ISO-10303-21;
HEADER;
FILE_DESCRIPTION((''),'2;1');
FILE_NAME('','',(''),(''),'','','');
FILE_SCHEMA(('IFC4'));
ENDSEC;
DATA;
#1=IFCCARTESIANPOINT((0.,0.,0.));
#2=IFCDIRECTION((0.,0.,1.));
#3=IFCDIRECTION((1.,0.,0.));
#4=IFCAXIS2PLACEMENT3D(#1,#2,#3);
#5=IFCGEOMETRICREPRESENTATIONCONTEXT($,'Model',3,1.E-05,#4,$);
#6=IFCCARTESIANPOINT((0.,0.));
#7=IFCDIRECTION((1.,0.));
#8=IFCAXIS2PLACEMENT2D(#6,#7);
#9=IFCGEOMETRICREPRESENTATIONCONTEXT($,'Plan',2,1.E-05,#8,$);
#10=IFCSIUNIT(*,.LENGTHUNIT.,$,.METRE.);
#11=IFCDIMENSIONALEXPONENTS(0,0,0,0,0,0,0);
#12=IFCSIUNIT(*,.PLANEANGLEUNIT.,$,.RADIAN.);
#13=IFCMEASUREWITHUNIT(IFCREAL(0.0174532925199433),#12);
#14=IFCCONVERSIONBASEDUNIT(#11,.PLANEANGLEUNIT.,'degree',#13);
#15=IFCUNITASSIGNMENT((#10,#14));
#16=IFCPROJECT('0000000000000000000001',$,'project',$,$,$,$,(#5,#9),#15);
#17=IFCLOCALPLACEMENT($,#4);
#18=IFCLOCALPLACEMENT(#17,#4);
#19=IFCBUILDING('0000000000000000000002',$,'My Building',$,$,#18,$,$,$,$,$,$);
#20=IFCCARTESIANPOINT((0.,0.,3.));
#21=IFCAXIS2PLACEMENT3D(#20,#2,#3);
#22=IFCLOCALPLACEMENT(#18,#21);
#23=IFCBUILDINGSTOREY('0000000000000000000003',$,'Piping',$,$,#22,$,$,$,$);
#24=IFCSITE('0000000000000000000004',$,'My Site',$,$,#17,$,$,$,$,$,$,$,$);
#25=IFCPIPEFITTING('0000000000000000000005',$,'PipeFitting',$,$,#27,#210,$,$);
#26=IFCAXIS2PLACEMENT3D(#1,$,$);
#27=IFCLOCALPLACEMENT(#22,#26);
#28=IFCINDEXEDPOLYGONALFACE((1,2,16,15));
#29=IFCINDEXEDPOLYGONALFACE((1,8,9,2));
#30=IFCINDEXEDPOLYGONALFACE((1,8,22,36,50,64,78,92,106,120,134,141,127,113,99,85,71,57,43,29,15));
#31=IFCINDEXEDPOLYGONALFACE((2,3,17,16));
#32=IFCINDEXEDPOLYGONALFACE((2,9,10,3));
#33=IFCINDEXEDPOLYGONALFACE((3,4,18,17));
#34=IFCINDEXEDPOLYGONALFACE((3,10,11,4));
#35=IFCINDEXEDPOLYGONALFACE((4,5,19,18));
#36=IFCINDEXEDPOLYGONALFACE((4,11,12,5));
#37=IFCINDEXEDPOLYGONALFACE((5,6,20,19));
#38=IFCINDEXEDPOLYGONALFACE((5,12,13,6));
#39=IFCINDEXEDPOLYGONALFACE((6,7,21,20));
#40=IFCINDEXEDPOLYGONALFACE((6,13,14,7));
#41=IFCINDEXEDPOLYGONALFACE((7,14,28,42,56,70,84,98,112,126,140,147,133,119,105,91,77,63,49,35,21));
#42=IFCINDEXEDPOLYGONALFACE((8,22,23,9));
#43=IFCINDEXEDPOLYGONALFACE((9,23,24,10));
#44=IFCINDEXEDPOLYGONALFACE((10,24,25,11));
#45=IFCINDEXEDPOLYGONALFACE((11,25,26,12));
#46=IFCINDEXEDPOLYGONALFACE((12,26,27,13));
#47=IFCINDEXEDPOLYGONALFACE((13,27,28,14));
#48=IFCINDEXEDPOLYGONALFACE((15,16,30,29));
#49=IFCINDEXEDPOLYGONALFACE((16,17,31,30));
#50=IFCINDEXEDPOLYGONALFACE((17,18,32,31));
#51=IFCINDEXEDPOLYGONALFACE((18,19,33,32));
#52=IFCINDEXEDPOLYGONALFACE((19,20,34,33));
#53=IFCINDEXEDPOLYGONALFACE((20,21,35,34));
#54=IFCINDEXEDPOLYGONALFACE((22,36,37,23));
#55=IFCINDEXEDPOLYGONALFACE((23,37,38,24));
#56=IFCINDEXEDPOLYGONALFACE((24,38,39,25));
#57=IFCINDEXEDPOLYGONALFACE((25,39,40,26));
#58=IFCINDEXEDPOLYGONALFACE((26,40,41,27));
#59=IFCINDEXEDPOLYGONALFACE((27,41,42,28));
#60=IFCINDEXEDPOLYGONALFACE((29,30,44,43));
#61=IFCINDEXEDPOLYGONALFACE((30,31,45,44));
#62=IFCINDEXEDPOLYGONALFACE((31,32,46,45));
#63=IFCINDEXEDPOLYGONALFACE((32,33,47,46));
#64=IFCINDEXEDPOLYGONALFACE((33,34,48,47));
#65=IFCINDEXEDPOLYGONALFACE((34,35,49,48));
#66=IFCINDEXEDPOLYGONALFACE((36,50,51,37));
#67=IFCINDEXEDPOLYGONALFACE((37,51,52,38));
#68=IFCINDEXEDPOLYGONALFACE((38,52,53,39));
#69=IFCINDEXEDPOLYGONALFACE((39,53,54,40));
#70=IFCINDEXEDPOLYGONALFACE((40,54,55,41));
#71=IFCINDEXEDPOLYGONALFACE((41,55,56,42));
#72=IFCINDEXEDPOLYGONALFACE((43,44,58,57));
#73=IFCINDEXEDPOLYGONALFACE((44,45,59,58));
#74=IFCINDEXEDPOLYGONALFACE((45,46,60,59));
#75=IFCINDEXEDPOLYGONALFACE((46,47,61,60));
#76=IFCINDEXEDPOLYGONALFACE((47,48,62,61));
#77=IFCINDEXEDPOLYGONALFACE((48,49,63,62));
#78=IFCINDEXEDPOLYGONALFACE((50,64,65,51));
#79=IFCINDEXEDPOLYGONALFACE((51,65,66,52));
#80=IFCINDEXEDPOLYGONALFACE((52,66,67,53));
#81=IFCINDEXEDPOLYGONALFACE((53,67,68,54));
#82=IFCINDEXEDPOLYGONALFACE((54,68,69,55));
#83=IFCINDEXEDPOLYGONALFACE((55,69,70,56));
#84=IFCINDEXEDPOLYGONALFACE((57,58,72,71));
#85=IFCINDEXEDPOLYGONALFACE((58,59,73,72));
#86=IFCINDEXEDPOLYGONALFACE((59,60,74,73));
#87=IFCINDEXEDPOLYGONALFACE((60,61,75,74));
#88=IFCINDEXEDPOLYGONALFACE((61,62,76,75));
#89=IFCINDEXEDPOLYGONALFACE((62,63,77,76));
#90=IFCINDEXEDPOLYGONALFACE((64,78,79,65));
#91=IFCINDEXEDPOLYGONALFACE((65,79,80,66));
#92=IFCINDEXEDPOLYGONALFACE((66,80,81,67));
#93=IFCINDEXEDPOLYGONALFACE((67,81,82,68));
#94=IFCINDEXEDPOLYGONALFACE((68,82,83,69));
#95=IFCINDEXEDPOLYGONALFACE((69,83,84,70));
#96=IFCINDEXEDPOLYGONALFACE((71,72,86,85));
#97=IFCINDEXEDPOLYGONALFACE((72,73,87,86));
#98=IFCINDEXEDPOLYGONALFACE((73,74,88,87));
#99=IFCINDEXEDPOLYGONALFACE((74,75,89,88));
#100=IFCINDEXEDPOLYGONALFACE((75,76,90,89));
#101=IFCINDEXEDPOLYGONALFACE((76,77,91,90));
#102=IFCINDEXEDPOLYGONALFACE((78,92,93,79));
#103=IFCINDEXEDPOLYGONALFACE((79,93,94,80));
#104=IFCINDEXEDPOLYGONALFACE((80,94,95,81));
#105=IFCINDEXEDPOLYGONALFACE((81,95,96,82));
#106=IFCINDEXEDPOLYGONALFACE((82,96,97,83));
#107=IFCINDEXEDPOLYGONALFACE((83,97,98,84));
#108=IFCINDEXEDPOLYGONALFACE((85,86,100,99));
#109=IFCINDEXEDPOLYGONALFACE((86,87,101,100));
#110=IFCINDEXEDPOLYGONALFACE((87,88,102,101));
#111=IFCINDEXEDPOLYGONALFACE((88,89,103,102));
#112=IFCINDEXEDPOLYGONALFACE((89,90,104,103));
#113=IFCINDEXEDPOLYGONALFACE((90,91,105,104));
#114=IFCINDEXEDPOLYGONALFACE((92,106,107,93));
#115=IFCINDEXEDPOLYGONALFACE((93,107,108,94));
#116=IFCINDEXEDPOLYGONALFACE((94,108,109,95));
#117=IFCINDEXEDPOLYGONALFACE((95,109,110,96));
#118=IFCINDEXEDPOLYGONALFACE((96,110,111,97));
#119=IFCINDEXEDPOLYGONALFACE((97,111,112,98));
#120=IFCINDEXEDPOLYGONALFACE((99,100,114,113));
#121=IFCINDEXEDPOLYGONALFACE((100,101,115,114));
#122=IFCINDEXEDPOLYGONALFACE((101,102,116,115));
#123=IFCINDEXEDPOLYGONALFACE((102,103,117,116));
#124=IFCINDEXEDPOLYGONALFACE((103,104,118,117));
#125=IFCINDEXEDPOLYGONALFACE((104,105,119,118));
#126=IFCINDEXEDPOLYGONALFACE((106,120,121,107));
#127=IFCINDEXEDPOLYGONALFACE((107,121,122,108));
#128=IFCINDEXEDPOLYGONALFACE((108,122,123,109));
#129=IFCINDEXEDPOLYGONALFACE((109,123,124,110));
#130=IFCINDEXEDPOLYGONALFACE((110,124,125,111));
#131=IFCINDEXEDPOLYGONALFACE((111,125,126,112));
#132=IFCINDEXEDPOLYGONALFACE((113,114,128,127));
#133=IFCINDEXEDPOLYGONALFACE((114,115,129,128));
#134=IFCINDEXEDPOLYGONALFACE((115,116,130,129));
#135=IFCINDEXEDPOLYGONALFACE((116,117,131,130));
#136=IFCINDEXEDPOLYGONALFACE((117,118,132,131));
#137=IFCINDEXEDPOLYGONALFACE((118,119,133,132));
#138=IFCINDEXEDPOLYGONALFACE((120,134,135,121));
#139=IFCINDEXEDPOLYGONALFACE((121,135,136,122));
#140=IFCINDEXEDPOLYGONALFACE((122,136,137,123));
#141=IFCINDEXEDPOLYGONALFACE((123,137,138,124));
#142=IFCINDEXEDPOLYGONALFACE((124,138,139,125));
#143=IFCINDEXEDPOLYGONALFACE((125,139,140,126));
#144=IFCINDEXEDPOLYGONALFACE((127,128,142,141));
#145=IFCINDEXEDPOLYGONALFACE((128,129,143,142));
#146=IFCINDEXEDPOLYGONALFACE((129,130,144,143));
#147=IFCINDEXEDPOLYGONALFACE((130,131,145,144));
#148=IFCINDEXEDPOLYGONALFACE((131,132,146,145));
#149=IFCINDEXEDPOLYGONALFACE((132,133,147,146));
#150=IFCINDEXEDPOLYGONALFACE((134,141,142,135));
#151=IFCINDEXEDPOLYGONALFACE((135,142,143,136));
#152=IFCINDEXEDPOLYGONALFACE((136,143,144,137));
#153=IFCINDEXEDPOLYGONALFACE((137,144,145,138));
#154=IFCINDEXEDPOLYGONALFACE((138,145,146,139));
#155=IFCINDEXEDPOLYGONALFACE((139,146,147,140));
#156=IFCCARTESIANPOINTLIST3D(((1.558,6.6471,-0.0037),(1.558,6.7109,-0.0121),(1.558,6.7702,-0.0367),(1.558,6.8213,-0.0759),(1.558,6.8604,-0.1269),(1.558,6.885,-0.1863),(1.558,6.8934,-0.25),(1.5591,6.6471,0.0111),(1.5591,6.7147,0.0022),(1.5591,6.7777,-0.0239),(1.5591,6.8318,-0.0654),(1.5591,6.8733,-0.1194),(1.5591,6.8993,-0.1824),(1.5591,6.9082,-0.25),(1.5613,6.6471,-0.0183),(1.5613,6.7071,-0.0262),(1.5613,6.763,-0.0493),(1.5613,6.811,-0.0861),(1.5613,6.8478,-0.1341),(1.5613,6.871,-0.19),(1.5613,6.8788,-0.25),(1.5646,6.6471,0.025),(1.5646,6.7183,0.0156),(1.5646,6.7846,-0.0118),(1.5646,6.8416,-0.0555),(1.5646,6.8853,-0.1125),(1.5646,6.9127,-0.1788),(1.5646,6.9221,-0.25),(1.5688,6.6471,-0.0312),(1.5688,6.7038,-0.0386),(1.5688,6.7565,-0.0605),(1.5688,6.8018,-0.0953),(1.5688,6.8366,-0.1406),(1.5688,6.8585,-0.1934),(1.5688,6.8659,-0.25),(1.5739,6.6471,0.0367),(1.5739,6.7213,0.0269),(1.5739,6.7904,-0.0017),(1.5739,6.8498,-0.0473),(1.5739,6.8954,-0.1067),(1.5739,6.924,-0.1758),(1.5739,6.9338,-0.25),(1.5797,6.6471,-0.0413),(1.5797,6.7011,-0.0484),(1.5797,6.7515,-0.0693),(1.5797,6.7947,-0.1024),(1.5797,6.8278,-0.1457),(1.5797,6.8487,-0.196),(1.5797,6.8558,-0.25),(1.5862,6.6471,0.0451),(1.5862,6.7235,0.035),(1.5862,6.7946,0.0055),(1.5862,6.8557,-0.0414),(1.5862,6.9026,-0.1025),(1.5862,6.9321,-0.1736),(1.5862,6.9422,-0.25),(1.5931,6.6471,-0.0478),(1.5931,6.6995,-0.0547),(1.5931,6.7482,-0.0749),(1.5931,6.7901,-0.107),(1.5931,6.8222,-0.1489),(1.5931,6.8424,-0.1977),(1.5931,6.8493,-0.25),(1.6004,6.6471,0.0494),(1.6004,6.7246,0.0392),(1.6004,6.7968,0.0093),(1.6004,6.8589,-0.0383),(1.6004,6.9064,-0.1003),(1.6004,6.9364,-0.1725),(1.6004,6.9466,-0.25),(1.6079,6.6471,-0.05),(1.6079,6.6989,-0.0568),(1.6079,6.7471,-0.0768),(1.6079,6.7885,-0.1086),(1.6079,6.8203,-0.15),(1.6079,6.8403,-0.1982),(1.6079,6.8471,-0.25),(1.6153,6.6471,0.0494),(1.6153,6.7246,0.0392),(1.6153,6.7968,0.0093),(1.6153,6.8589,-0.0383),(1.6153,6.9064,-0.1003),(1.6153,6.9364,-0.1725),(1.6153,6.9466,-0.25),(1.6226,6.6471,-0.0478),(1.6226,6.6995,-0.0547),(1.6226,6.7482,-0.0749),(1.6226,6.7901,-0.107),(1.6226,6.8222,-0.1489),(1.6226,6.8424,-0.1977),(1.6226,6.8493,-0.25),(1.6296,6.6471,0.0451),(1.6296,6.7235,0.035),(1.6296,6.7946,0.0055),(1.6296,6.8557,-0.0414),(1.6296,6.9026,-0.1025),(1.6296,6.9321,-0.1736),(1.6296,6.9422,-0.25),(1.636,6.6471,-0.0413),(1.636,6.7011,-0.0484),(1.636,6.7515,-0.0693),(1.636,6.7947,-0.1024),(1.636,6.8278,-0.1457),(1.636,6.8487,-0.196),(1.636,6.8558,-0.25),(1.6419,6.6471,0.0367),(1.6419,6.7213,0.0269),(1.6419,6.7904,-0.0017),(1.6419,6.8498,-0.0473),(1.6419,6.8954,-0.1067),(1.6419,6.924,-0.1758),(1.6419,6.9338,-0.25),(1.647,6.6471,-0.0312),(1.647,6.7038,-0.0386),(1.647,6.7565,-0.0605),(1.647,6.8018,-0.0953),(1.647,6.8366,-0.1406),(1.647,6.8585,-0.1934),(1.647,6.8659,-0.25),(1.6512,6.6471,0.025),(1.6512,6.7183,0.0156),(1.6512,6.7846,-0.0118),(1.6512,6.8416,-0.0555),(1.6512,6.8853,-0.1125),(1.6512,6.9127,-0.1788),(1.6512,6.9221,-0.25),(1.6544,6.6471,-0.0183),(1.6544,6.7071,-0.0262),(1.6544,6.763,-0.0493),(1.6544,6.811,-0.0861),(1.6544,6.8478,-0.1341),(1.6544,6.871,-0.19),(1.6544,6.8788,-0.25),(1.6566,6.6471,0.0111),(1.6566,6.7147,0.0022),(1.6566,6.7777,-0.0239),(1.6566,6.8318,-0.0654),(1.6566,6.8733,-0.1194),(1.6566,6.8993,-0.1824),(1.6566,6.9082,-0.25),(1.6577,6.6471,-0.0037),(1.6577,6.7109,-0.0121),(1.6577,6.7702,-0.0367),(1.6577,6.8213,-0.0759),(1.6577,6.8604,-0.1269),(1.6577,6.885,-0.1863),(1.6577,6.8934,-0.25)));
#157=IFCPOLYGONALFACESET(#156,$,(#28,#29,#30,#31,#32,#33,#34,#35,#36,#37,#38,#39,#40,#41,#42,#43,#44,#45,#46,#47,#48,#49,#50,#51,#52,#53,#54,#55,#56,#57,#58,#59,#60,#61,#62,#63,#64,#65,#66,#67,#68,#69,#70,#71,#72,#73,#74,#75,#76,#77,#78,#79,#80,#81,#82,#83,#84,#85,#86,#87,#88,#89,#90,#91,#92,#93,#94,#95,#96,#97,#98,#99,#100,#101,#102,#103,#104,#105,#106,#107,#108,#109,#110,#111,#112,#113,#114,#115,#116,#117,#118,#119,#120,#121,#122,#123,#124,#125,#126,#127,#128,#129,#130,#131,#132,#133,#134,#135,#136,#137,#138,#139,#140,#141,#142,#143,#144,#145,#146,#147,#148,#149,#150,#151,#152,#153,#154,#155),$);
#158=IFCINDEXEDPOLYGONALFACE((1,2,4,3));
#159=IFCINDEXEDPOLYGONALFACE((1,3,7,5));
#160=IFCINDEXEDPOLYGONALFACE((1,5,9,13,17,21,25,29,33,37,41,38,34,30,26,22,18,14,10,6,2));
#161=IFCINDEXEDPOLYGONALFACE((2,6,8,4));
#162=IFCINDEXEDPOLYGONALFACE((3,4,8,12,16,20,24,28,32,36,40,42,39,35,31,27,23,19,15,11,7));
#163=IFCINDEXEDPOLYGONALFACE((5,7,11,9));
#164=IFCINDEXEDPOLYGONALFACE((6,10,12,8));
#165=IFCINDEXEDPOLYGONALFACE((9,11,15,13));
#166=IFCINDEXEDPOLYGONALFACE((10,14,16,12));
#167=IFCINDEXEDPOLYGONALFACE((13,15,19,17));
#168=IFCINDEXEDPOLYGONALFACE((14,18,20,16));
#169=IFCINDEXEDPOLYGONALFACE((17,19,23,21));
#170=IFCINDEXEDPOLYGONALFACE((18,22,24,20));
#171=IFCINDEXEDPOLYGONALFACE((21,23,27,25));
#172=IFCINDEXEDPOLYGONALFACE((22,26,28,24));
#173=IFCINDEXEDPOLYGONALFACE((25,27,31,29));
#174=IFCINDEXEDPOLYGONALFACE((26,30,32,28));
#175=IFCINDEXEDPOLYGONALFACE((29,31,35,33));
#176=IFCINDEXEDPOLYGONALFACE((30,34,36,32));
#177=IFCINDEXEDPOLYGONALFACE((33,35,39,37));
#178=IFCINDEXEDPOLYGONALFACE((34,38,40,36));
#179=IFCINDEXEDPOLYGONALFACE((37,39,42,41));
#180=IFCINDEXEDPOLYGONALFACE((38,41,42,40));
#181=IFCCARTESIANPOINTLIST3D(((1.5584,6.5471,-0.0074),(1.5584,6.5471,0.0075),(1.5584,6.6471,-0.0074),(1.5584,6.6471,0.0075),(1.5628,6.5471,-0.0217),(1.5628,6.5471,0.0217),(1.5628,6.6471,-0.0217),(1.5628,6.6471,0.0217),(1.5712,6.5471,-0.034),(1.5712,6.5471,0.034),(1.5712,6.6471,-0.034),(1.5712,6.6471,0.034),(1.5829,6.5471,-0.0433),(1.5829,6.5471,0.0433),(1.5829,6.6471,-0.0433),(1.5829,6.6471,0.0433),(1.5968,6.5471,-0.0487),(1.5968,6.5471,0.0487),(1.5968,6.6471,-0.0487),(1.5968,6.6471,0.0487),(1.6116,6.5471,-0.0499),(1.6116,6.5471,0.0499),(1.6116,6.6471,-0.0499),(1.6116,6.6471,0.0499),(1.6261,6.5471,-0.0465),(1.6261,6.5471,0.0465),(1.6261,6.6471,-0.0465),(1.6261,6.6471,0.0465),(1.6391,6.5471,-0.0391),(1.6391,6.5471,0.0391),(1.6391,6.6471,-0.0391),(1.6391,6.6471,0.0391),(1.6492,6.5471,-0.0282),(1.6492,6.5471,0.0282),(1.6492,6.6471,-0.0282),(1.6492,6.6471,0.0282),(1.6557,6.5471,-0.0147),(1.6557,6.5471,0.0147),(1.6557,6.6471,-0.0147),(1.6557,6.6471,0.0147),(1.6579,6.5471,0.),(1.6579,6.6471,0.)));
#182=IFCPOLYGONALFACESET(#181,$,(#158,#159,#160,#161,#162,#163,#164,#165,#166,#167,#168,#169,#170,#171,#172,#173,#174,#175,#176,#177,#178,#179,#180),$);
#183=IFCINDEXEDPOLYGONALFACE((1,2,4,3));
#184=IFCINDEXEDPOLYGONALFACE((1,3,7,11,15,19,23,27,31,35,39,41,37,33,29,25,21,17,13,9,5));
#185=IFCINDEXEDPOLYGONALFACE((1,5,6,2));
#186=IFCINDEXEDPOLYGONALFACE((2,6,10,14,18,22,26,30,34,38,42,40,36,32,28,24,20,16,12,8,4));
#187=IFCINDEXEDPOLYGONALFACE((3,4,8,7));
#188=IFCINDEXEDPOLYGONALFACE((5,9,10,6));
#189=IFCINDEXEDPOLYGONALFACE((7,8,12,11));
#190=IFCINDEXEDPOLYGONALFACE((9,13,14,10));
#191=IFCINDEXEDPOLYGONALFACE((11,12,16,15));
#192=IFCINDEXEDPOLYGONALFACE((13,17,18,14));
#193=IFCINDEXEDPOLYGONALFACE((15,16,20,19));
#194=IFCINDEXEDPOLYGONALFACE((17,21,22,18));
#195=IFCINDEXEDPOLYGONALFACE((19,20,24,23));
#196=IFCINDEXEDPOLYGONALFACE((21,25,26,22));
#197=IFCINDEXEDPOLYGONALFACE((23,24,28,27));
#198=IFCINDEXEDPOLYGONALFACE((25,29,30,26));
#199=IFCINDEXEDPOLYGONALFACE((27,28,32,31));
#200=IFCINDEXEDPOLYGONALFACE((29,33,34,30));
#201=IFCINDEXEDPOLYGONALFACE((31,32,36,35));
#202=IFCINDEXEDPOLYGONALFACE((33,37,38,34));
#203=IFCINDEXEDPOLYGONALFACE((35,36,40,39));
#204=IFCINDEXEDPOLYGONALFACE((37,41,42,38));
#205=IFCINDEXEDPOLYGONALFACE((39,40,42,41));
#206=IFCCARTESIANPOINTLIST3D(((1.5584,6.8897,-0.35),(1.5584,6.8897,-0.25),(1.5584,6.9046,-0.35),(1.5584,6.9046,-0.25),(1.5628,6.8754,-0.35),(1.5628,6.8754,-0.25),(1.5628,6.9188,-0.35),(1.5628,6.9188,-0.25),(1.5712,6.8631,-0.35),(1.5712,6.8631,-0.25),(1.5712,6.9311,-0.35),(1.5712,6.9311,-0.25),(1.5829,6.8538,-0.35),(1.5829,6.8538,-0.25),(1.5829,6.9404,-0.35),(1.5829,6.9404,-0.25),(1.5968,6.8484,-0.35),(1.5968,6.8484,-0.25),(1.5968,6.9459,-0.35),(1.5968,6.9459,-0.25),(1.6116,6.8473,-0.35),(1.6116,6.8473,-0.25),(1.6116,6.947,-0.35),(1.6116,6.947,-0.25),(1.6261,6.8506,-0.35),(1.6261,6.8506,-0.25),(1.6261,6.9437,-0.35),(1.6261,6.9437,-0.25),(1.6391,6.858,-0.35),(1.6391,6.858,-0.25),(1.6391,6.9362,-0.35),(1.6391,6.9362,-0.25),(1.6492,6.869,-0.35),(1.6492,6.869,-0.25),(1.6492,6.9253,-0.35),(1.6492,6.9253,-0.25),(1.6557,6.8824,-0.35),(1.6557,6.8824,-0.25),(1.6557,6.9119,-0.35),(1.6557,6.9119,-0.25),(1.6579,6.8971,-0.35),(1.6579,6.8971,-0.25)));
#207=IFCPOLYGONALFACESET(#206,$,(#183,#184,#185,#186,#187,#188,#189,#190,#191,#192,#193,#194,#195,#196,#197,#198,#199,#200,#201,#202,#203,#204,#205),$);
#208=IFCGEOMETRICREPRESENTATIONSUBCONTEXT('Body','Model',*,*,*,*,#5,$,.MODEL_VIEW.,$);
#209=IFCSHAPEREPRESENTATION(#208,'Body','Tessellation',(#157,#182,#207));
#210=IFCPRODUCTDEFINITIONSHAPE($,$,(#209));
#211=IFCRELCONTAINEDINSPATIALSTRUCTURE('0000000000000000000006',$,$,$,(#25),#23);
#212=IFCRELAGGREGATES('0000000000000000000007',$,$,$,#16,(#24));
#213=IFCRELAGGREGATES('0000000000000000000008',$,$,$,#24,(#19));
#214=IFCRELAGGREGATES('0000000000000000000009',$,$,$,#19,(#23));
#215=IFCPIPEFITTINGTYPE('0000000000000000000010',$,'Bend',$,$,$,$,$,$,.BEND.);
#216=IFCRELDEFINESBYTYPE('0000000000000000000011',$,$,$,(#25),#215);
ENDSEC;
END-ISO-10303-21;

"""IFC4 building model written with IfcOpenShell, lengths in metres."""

from ifc_helpers import new_model, entity, si_unit, converted_unit, frame, origin_with_axes, origin_2d_with_axis, place, context, subcontext, project, spatial, circle, extrude, source, transform, mapped, type_object, type_shapes, element, save


model = new_model("IFC4")

# Units and contexts
model_context = context("Model", 3, precision=1e-05, world=origin_with_axes())
plan_context = context("Plan", 2, precision=1e-05, world=origin_2d_with_axis())
body_context = subcontext(model_context, "Body", "Model", "MODEL_VIEW")
ifc_project = project(units=[si_unit("LENGTHUNIT", "METRE"), converted_unit("PLANEANGLEUNIT", "degree", entity("IfcReal", 0.0174532925199433), si_unit("PLANEANGLEUNIT", "RADIAN"), dimensions=[0, 0, 0, 0, 0, 0, 0])], contexts=[model_context, plan_context])

# Site, building, storey
site_placement = place(None, origin_with_axes())
site = spatial("IfcSite", under=ifc_project, at=site_placement, Name="My Site")
building_placement = place(site_placement, origin_with_axes())
building = spatial("IfcBuilding", under=site, at=building_placement, Name="My Building")
storey_placement = place(building_placement, frame((0.0, 0.0, 3.0), z_axis=(0.0, 0.0, 1.0), x_axis=(1.0, 0.0, 0.0)))
storey = spatial("IfcBuildingStorey", under=building, at=storey_placement, Name="Piping")

# Pipe fitting
pipe_fitting_type = type_object("IfcPipeFittingType", Name="Bend", PredefinedType="BEND")
shared_shape = source(origin_with_axes(), body_context, "Body", "SolidModel", [
    entity("IfcSweptDiskSolid", entity("IfcIndexedPolyCurve", entity("IfcCartesianPointList3D", [[0.0, 0.0, -0.1], [0.0, -0.0732, -0.2768], [0.0, -0.25, -0.35]]), [entity("IfcArcIndex", [1, 2, 3])]), 0.05),
    extrude(circle(Radius=0.05), origin_with_axes(), (0.0, 0.0, -1.0), 0.1),
    extrude(circle(Radius=0.05), frame((0.0, -0.25, -0.35), z_axis=(0.0, -1.0, 0.0), x_axis=(1.0, 0.0, 0.0)), (0.0, 0.0, 1.0), 0.1),
])
type_shapes(pipe_fitting_type, [shared_shape])
for number, where, z_axis, x_axis, name in (
    (1, (1.6079, 6.5471, 0.0), (0.0, -1.0, 0.0), (1.0, 0.0, 0.0), "PipeFitting"),
):
    element("IfcPipeFitting", number, at=place(storey_placement, frame(where, z_axis=z_axis, x_axis=x_axis)), inside=storey, type_object=pipe_fitting_type, Name=name, context=body_context, shape_type="MappedRepresentation", body=[
        mapped(shared_shape, transform((0.0, 0.0, 0.0), x_axis=(1.0, 0.0, 0.0), y_axis=(0.0, 1.0, 0.0), z_axis=(0.0, 0.0, 1.0), scale=1.0)),
    ])

save(model, "model.ifc")
